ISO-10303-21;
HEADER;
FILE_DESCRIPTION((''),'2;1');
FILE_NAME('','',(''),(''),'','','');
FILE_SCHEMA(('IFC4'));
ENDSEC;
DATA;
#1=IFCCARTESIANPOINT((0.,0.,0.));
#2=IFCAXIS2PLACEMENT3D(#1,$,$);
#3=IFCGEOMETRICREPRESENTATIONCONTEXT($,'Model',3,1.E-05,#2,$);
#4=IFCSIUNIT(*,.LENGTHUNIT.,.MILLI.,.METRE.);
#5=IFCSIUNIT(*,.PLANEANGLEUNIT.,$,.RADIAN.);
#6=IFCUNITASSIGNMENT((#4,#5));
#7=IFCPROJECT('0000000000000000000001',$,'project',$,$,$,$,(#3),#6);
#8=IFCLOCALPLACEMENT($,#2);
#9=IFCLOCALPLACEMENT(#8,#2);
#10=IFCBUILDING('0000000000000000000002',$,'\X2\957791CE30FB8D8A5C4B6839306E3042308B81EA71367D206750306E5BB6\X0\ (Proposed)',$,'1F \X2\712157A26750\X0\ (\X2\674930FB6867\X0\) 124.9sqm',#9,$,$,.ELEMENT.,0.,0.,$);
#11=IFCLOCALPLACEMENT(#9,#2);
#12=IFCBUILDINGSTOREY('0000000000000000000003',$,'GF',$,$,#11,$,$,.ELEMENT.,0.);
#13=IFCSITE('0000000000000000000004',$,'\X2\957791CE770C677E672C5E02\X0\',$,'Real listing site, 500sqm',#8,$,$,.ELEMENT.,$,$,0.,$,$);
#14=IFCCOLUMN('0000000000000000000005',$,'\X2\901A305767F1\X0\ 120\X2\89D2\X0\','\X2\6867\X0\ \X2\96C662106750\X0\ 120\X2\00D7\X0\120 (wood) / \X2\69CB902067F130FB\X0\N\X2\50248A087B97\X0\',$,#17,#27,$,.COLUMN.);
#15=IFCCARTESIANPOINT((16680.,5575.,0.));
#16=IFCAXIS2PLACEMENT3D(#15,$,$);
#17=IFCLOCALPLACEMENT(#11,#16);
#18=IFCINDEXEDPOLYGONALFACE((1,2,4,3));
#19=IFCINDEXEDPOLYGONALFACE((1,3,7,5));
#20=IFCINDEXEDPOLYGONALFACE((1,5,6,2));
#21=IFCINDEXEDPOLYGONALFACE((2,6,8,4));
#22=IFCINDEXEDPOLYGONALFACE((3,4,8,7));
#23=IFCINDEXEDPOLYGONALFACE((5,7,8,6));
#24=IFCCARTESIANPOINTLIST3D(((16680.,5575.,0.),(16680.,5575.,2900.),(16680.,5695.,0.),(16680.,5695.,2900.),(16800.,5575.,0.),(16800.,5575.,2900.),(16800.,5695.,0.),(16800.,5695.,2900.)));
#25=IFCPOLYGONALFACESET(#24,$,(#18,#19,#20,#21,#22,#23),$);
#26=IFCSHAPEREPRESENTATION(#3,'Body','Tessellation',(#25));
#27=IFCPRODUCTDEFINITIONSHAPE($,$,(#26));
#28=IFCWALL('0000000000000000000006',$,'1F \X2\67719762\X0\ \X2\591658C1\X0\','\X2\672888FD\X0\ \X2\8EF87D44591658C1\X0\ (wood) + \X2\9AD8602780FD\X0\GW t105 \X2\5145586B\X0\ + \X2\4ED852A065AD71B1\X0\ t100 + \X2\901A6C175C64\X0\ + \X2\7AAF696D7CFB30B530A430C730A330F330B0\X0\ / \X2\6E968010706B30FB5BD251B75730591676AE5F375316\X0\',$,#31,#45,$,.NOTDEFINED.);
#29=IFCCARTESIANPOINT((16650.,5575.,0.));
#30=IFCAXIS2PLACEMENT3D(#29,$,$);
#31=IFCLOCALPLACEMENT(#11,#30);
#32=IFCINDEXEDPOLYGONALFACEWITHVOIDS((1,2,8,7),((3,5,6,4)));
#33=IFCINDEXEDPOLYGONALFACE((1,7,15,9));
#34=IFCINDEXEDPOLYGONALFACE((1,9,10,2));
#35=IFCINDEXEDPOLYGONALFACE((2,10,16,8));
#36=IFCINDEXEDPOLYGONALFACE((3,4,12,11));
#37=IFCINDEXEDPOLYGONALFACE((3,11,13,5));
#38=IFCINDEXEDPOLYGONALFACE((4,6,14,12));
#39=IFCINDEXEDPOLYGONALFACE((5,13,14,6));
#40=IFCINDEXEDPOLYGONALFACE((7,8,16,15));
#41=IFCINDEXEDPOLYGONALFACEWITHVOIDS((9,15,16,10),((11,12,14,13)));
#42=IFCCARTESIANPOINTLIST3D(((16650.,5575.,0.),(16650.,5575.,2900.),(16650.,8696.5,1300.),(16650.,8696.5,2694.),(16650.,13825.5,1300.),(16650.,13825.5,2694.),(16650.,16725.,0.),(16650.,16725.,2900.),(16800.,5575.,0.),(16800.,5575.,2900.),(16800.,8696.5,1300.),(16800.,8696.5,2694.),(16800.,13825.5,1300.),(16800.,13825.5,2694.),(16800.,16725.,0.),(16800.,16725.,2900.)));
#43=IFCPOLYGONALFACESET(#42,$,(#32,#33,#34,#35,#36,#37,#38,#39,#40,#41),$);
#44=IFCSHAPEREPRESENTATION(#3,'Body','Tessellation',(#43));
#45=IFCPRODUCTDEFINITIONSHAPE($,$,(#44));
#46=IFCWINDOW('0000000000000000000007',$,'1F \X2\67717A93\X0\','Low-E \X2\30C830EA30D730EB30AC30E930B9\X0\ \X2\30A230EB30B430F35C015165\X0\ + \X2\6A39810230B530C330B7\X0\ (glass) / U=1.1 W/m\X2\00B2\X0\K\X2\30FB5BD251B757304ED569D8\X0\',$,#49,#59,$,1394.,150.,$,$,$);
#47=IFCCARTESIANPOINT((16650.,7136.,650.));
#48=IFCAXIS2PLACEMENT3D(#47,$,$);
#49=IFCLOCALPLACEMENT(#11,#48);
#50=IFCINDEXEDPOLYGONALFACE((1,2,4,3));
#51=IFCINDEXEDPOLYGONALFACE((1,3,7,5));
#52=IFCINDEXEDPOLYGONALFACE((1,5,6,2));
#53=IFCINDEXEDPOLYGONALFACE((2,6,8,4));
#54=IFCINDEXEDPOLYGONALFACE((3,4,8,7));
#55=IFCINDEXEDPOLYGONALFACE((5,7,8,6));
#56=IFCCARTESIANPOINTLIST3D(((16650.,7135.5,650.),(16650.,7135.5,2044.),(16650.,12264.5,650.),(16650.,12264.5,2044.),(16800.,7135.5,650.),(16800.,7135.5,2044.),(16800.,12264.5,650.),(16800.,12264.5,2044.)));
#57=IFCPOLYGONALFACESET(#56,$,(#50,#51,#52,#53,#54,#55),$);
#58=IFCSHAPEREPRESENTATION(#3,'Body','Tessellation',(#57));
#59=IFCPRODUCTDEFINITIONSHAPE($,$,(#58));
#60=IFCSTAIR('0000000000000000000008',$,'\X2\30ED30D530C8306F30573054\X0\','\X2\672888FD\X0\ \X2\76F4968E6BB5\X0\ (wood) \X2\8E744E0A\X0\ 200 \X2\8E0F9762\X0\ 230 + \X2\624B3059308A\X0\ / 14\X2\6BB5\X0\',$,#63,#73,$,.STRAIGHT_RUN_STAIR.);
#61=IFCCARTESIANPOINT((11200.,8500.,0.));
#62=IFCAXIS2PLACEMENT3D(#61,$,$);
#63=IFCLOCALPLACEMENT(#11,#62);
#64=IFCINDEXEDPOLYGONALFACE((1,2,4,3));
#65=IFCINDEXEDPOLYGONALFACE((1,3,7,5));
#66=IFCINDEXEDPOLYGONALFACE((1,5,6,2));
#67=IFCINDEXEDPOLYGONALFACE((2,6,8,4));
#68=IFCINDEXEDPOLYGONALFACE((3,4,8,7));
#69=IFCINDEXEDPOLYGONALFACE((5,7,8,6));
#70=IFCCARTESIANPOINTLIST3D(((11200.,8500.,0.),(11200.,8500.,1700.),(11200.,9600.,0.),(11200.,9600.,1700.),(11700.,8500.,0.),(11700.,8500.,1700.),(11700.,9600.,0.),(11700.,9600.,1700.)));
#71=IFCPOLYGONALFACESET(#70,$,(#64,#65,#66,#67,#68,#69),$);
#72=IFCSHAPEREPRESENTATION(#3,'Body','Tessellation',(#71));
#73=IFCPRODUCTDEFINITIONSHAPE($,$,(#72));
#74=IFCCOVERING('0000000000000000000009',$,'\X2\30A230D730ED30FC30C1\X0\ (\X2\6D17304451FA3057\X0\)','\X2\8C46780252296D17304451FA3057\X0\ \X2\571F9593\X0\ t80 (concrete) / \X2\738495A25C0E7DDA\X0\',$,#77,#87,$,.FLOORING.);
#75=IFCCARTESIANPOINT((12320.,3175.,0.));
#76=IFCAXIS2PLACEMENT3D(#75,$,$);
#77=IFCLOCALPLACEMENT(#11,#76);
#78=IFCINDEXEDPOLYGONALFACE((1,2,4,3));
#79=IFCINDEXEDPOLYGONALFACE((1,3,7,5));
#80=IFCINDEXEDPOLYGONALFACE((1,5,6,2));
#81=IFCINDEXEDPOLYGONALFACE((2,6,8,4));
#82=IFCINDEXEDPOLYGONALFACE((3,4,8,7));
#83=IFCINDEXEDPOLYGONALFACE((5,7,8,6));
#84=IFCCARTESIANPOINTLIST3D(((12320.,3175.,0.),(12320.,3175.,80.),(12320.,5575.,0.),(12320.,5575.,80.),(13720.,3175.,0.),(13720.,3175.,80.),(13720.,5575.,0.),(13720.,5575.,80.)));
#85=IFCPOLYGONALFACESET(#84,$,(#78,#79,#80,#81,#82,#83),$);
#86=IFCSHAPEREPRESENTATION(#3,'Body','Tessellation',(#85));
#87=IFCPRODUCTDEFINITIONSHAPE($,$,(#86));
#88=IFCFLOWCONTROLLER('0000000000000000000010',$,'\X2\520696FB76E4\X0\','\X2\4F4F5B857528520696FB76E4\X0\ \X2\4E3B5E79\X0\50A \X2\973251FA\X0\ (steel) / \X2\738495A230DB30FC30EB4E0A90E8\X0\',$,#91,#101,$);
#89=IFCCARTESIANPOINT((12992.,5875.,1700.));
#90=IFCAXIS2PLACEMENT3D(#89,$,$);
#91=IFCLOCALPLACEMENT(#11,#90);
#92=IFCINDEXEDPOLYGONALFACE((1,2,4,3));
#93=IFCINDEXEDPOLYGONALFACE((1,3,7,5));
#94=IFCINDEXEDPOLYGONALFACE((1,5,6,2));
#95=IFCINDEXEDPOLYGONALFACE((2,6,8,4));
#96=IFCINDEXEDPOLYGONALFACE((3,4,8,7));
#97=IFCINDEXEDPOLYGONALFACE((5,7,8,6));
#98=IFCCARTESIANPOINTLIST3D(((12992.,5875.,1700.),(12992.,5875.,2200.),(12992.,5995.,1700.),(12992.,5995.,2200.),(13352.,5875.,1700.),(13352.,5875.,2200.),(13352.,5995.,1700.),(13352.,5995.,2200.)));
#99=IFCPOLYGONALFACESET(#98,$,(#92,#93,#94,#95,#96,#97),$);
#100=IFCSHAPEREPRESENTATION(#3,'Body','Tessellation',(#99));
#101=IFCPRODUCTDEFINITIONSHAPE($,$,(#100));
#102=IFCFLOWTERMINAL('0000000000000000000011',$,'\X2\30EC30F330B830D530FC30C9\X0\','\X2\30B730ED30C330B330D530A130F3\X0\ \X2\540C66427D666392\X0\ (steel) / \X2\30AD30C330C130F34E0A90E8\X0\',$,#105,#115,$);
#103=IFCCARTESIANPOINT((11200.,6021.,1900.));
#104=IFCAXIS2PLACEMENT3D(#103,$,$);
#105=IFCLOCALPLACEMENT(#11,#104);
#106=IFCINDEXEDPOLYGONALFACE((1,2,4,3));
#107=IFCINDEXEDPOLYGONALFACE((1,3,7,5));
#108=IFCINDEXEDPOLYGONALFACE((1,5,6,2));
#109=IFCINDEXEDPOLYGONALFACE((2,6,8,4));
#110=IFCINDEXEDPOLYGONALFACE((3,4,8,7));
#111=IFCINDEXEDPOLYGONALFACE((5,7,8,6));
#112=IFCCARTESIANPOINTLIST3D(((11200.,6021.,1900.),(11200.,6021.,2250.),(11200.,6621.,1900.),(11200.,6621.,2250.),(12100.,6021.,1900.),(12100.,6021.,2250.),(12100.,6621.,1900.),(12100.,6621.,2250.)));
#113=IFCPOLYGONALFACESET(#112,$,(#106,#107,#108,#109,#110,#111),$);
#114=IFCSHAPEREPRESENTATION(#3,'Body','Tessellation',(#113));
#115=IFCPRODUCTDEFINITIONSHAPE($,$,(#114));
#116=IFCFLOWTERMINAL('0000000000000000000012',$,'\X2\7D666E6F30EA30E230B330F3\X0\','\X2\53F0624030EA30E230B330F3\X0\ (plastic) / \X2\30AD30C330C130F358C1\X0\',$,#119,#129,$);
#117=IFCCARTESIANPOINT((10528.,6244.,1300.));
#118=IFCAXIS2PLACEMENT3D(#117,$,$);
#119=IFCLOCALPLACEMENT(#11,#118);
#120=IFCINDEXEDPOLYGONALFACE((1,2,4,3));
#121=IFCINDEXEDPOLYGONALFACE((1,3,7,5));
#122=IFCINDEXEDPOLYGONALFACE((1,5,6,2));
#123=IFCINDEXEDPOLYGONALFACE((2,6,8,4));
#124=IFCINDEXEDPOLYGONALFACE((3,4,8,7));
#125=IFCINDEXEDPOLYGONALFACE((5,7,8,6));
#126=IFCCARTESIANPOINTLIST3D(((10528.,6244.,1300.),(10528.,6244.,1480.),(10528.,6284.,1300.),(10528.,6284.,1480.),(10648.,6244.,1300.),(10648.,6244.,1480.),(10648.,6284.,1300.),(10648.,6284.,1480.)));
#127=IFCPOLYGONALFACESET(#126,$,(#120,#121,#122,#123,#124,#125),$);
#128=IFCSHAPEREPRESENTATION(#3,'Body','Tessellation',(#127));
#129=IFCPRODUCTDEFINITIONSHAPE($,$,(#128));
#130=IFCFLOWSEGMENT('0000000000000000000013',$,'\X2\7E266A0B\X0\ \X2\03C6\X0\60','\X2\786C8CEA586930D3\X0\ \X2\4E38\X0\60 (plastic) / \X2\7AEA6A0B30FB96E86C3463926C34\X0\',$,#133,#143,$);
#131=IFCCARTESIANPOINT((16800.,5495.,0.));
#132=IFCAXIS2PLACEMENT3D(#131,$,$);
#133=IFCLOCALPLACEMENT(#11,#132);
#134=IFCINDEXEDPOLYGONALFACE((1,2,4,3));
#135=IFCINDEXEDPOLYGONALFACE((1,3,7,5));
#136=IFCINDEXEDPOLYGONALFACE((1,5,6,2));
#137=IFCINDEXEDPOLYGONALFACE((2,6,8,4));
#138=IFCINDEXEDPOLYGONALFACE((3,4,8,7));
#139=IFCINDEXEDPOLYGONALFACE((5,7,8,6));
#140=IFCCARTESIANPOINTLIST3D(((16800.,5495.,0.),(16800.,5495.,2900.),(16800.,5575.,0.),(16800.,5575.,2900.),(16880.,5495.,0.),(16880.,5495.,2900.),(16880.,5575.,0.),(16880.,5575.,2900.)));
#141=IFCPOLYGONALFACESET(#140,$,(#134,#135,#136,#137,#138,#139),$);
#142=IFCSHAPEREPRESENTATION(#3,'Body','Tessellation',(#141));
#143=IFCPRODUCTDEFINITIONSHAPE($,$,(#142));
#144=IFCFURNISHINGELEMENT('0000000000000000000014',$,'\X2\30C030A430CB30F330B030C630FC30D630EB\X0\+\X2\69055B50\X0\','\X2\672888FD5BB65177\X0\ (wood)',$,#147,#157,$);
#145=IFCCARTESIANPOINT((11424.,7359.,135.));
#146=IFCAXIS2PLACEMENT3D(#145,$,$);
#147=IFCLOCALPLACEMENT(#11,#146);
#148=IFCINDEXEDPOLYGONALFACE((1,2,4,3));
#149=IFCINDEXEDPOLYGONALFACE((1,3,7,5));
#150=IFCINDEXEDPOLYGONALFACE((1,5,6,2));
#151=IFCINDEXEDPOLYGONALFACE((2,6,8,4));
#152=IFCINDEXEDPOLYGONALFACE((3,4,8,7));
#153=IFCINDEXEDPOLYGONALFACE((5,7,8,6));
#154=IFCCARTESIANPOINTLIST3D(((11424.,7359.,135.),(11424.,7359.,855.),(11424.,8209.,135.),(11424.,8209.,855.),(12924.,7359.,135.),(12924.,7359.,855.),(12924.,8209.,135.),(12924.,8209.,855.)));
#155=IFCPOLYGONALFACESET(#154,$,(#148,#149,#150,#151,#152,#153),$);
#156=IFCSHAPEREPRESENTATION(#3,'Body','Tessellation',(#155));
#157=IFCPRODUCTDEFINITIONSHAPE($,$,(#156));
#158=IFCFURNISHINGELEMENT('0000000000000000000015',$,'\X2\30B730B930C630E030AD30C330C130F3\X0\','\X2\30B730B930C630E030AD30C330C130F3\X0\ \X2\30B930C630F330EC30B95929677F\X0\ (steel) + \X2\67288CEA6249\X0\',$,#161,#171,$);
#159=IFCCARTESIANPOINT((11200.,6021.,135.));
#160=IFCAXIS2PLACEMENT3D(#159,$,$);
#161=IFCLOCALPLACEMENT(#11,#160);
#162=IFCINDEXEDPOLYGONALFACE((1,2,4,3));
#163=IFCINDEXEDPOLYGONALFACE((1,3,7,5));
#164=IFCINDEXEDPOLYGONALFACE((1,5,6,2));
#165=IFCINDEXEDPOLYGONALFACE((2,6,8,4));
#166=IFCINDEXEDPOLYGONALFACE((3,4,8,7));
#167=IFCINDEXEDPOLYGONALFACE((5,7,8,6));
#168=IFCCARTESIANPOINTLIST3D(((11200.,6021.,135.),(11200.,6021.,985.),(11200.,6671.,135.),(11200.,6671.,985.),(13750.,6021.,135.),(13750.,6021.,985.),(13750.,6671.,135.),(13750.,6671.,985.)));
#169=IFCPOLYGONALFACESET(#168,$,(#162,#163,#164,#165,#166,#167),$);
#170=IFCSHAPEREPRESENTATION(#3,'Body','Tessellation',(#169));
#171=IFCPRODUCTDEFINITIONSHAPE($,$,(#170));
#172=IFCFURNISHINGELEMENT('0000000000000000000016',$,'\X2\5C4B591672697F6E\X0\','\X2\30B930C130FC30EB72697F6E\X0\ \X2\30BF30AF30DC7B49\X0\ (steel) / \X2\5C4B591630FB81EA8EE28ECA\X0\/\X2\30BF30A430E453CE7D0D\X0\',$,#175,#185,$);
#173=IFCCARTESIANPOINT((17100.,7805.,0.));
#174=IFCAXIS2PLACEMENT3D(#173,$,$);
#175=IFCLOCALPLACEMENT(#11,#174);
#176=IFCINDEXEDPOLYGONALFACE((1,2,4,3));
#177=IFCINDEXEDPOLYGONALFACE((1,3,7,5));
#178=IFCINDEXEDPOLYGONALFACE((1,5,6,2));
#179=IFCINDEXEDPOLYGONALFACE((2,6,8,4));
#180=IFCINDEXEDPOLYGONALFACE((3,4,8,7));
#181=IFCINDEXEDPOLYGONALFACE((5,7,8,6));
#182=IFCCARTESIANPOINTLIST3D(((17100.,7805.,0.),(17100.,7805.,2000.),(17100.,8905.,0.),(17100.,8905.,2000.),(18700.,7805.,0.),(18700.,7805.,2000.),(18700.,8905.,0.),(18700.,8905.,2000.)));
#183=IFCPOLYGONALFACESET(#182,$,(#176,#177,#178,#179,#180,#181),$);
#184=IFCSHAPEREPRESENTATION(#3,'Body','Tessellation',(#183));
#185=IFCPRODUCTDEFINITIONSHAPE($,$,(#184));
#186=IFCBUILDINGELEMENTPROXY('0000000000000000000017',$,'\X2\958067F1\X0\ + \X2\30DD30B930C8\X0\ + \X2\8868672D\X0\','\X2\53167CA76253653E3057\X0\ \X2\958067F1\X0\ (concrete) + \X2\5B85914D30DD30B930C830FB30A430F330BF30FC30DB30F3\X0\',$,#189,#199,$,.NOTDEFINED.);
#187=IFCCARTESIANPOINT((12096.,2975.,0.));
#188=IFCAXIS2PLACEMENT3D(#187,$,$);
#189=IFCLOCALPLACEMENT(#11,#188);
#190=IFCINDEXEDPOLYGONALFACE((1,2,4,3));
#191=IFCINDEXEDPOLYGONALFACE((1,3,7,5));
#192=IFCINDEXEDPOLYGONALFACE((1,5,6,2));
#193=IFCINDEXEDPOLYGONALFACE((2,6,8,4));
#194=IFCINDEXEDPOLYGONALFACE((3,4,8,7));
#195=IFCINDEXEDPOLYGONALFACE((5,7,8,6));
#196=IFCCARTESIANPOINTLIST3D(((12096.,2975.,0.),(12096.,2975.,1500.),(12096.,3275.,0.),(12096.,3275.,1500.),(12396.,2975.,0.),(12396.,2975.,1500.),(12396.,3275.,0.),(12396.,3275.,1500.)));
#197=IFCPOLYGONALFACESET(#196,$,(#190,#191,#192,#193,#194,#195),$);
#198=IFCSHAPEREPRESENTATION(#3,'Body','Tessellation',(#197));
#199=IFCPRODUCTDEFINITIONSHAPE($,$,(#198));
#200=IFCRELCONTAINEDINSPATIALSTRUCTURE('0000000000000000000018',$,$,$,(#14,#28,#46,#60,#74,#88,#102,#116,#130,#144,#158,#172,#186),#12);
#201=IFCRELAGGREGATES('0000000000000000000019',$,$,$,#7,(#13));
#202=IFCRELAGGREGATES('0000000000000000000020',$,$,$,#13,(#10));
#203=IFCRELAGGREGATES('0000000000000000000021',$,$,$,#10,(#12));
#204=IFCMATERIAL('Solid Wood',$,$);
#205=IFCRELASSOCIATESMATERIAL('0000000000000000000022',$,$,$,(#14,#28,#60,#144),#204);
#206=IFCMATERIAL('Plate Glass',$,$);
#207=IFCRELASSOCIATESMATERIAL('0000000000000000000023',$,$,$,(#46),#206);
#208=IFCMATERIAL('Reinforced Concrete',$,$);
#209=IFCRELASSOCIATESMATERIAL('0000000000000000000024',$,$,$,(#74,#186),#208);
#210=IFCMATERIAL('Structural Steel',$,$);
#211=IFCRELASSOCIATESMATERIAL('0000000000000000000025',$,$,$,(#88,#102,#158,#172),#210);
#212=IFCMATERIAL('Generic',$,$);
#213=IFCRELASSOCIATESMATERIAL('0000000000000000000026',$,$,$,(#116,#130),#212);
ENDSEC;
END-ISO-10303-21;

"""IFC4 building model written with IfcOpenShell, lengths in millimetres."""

from ifc_helpers import new_model, si_unit, frame, frame_2d, origin, place, context, project, spatial, rectangle, extrude, material, element, fill, save


model = new_model("IFC4")

# Units and contexts
model_context = context("Model", 3, precision=1e-05, world=origin())
ifc_project = project(units=[si_unit("LENGTHUNIT", "METRE", prefix="MILLI"), si_unit("PLANEANGLEUNIT", "RADIAN")], contexts=[model_context])

# Site, building, storey
site_placement = place(None, origin())
site = spatial("IfcSite", under=ifc_project, at=site_placement, Name="長野県松本市", ObjectType="Real listing site, 500sqm", CompositionType="ELEMENT", RefElevation=0.0)
building_placement = place(site_placement, origin())
building = spatial("IfcBuilding", under=site, at=building_placement, Name="長野・越屋根のある自然素材の家 (Proposed)", ObjectType="1F 無垢材 (杉・桧) 124.9sqm", CompositionType="ELEMENT", ElevationOfRefHeight=0.0, ElevationOfTerrain=0.0)
storey_placement = place(building_placement, origin())
storey = spatial("IfcBuildingStorey", under=building, at=storey_placement, Name="GF", CompositionType="ELEMENT", Elevation=0.0)

# Column
ifc_material_1 = material(Name="Solid Wood")
column_1_placement = place(storey_placement, frame((16680.0, 5575.0, 0.0)))
element("IfcColumn", 1, at=column_1_placement, inside=storey, material=ifc_material_1, Name="通し柱 120角", Description="桧 集成材 120×120 (wood) / 構造柱・N値計算", PredefinedType="COLUMN", context=model_context, shape_type="SweptSolid", body=[
    extrude(rectangle(XDim=120.0, YDim=120.0, at=frame_2d((60.0, 60.0))), frame((16680.0, 5575.0, 0.0)), (0.0, 0.0, 1.0), 2900.0),
])

# Wall, opening, window
wall_1_placement = place(storey_placement, frame((16650.0, 5575.0, 0.0)))
wall_1 = element("IfcWall", 2, at=wall_1_placement, inside=storey, material=ifc_material_1, Name="1F 東面 外壁", Description="木製 軸組外壁 (wood) + 高性能GW t105 充填 + 付加断熱 t100 + 通気層 + 窯業系サイディング / 準耐火・寒冷地外皮強化", PredefinedType="NOTDEFINED", context=model_context, shape_type="SweptSolid", body=[
    extrude(rectangle(XDim=150.0, YDim=11150.0, at=frame_2d((75.0, 5575.0))), frame((16650.0, 5575.0, 0.0)), (0.0, 0.0, 1.0), 2900.0),
])
opening_placement = place(storey_placement, frame((16650.0, 7136.0, 650.0)))
opening = element("IfcOpeningElement", 3, at=opening_placement, cuts=wall_1, PredefinedType="NOTDEFINED", context=model_context, shape_type="SweptSolid", body=[
    extrude(rectangle(XDim=150.0, YDim=5129.0, at=frame_2d((75.0, 2564.0))), frame((16650.0, 7136.0, 650.0)), (0.0, 0.0, 1.0), 1394.0),
])
ifc_material_2 = material(Name="Plate Glass")
window_placement = place(storey_placement, frame((16650.0, 7136.0, 650.0)))
window = element("IfcWindow", 4, at=window_placement, inside=storey, material=ifc_material_2, Name="1F 東窓", Description="Low-E トリプルガラス アルゴン封入 + 樹脂サッシ (glass) / U=1.1 W/m²K・寒冷地仕様", OverallHeight=1394.0, OverallWidth=150.0, context=model_context, shape_type="SweptSolid", body=[
    extrude(rectangle(XDim=150.0, YDim=5129.0, at=frame_2d((75.0, 2564.0))), frame((16650.0, 7136.0, 650.0)), (0.0, 0.0, 1.0), 1394.0),
])
fill(opening, window)

# Stair
stair_placement = place(storey_placement, frame((11200.0, 8500.0, 0.0)))
element("IfcStair", 5, at=stair_placement, inside=storey, material=ifc_material_1, Name="ロフトはしご", Description="木製 直階段 (wood) 蹴上 200 踏面 230 + 手すり / 14段", PredefinedType="STRAIGHT_RUN_STAIR", context=model_context, shape_type="SweptSolid", body=[
    extrude(rectangle(XDim=500.0, YDim=1100.0, at=frame_2d((250.0, 550.0))), frame((11200.0, 8500.0, 0.0)), (0.0, 0.0, 1.0), 1700.0),
])

# Covering
ifc_material_3 = material(Name="Reinforced Concrete")
covering_placement = place(storey_placement, frame((12320.0, 3175.0, 0.0)))
element("IfcCovering", 6, at=covering_placement, inside=storey, material=ifc_material_3, Name="アプローチ (洗い出し)", Description="豆砂利洗い出し 土間 t80 (concrete) / 玄関導線", PredefinedType="FLOORING", context=model_context, shape_type="SweptSolid", body=[
    extrude(rectangle(XDim=1400.0, YDim=2400.0, at=frame_2d((700.0, 1200.0))), frame((12320.0, 3175.0, 0.0)), (0.0, 0.0, 1.0), 80.0),
])

# Flow controller
ifc_material_4 = material(Name="Structural Steel")
flow_controller_placement = place(storey_placement, frame((12992.0, 5875.0, 1700.0)))
element("IfcFlowController", 7, at=flow_controller_placement, inside=storey, material=ifc_material_4, Name="分電盤", Description="住宅用分電盤 主幹50A 露出 (steel) / 玄関ホール上部", context=model_context, shape_type="SweptSolid", body=[
    extrude(rectangle(XDim=360.0, YDim=120.0, at=frame_2d((180.0, 60.0))), frame((12992.0, 5875.0, 1700.0)), (0.0, 0.0, 1.0), 500.0),
])

# Flow terminals
flow_terminal_1_placement = place(storey_placement, frame((11200.0, 6021.0, 1900.0)))
element("IfcFlowTerminal", 8, at=flow_terminal_1_placement, inside=storey, material=ifc_material_4, Name="レンジフード", Description="シロッコファン 同時給排 (steel) / キッチン上部", context=model_context, shape_type="SweptSolid", body=[
    extrude(rectangle(XDim=900.0, YDim=600.0, at=frame_2d((450.0, 300.0))), frame((11200.0, 6021.0, 1900.0)), (0.0, 0.0, 1.0), 350.0),
])
ifc_material_5 = material(Name="Generic")
flow_terminal_2_placement = place(storey_placement, frame((10528.0, 6244.0, 1300.0)))
element("IfcFlowTerminal", 9, at=flow_terminal_2_placement, inside=storey, material=ifc_material_5, Name="給湯リモコン", Description="台所リモコン (plastic) / キッチン壁", context=model_context, shape_type="SweptSolid", body=[
    extrude(rectangle(XDim=120.0, YDim=40.0, at=frame_2d((60.0, 20.0))), frame((10528.0, 6244.0, 1300.0)), (0.0, 0.0, 1.0), 180.0),
])

# Flow segment
flow_segment_placement = place(storey_placement, frame((16800.0, 5495.0, 0.0)))
element("IfcFlowSegment", 10, at=flow_segment_placement, inside=storey, material=ifc_material_5, Name="縦樋 φ60", Description="硬質塩ビ 丸60 (plastic) / 竪樋・雨水排水", context=model_context, shape_type="SweptSolid", body=[
    extrude(rectangle(XDim=80.0, YDim=80.0, at=frame_2d((40.0, 40.0))), frame((16800.0, 5495.0, 0.0)), (0.0, 0.0, 1.0), 2900.0),
])

# Furnishing elements
furnishing_1_placement = place(storey_placement, frame((11424.0, 7359.0, 135.0)))
element("IfcFurnishingElement", 11, at=furnishing_1_placement, inside=storey, material=ifc_material_1, Name="ダイニングテーブル+椅子", Description="木製家具 (wood)", context=model_context, shape_type="SweptSolid", body=[
    extrude(rectangle(XDim=1500.0, YDim=850.0, at=frame_2d((750.0, 425.0))), frame((11424.0, 7359.0, 135.0)), (0.0, 0.0, 1.0), 720.0),
])
furnishing_2_placement = place(storey_placement, frame((11200.0, 6021.0, 135.0)))
element("IfcFurnishingElement", 12, at=furnishing_2_placement, inside=storey, material=ifc_material_4, Name="システムキッチン", Description="システムキッチン ステンレス天板 (steel) + 木質扉", context=model_context, shape_type="SweptSolid", body=[
    extrude(rectangle(XDim=2550.0, YDim=650.0, at=frame_2d((1275.0, 325.0))), frame((11200.0, 6021.0, 135.0)), (0.0, 0.0, 1.0), 850.0),
])
furnishing_3_placement = place(storey_placement, frame((17100.0, 7805.0, 0.0)))
element("IfcFurnishingElement", 13, at=furnishing_3_placement, inside=storey, material=ifc_material_4, Name="屋外物置", Description="スチール物置 タクボ等 (steel) / 屋外・自転車/タイヤ収納", context=model_context, shape_type="SweptSolid", body=[
    extrude(rectangle(XDim=1600.0, YDim=1100.0, at=frame_2d((800.0, 550.0))), frame((17100.0, 7805.0, 0.0)), (0.0, 0.0, 1.0), 2000.0),
])

# Building element proxy
proxy_placement = place(storey_placement, frame((12096.0, 2975.0, 0.0)))
element("IfcBuildingElementProxy", 14, at=proxy_placement, inside=storey, material=ifc_material_3, Name="門柱 + ポスト + 表札", Description="化粧打放し 門柱 (concrete) + 宅配ポスト・インターホン", PredefinedType="NOTDEFINED", context=model_context, shape_type="SweptSolid", body=[
    extrude(rectangle(XDim=300.0, YDim=300.0, at=frame_2d((150.0, 150.0))), frame((12096.0, 2975.0, 0.0)), (0.0, 0.0, 1.0), 1500.0),
])

save(model, "model.ifc")
